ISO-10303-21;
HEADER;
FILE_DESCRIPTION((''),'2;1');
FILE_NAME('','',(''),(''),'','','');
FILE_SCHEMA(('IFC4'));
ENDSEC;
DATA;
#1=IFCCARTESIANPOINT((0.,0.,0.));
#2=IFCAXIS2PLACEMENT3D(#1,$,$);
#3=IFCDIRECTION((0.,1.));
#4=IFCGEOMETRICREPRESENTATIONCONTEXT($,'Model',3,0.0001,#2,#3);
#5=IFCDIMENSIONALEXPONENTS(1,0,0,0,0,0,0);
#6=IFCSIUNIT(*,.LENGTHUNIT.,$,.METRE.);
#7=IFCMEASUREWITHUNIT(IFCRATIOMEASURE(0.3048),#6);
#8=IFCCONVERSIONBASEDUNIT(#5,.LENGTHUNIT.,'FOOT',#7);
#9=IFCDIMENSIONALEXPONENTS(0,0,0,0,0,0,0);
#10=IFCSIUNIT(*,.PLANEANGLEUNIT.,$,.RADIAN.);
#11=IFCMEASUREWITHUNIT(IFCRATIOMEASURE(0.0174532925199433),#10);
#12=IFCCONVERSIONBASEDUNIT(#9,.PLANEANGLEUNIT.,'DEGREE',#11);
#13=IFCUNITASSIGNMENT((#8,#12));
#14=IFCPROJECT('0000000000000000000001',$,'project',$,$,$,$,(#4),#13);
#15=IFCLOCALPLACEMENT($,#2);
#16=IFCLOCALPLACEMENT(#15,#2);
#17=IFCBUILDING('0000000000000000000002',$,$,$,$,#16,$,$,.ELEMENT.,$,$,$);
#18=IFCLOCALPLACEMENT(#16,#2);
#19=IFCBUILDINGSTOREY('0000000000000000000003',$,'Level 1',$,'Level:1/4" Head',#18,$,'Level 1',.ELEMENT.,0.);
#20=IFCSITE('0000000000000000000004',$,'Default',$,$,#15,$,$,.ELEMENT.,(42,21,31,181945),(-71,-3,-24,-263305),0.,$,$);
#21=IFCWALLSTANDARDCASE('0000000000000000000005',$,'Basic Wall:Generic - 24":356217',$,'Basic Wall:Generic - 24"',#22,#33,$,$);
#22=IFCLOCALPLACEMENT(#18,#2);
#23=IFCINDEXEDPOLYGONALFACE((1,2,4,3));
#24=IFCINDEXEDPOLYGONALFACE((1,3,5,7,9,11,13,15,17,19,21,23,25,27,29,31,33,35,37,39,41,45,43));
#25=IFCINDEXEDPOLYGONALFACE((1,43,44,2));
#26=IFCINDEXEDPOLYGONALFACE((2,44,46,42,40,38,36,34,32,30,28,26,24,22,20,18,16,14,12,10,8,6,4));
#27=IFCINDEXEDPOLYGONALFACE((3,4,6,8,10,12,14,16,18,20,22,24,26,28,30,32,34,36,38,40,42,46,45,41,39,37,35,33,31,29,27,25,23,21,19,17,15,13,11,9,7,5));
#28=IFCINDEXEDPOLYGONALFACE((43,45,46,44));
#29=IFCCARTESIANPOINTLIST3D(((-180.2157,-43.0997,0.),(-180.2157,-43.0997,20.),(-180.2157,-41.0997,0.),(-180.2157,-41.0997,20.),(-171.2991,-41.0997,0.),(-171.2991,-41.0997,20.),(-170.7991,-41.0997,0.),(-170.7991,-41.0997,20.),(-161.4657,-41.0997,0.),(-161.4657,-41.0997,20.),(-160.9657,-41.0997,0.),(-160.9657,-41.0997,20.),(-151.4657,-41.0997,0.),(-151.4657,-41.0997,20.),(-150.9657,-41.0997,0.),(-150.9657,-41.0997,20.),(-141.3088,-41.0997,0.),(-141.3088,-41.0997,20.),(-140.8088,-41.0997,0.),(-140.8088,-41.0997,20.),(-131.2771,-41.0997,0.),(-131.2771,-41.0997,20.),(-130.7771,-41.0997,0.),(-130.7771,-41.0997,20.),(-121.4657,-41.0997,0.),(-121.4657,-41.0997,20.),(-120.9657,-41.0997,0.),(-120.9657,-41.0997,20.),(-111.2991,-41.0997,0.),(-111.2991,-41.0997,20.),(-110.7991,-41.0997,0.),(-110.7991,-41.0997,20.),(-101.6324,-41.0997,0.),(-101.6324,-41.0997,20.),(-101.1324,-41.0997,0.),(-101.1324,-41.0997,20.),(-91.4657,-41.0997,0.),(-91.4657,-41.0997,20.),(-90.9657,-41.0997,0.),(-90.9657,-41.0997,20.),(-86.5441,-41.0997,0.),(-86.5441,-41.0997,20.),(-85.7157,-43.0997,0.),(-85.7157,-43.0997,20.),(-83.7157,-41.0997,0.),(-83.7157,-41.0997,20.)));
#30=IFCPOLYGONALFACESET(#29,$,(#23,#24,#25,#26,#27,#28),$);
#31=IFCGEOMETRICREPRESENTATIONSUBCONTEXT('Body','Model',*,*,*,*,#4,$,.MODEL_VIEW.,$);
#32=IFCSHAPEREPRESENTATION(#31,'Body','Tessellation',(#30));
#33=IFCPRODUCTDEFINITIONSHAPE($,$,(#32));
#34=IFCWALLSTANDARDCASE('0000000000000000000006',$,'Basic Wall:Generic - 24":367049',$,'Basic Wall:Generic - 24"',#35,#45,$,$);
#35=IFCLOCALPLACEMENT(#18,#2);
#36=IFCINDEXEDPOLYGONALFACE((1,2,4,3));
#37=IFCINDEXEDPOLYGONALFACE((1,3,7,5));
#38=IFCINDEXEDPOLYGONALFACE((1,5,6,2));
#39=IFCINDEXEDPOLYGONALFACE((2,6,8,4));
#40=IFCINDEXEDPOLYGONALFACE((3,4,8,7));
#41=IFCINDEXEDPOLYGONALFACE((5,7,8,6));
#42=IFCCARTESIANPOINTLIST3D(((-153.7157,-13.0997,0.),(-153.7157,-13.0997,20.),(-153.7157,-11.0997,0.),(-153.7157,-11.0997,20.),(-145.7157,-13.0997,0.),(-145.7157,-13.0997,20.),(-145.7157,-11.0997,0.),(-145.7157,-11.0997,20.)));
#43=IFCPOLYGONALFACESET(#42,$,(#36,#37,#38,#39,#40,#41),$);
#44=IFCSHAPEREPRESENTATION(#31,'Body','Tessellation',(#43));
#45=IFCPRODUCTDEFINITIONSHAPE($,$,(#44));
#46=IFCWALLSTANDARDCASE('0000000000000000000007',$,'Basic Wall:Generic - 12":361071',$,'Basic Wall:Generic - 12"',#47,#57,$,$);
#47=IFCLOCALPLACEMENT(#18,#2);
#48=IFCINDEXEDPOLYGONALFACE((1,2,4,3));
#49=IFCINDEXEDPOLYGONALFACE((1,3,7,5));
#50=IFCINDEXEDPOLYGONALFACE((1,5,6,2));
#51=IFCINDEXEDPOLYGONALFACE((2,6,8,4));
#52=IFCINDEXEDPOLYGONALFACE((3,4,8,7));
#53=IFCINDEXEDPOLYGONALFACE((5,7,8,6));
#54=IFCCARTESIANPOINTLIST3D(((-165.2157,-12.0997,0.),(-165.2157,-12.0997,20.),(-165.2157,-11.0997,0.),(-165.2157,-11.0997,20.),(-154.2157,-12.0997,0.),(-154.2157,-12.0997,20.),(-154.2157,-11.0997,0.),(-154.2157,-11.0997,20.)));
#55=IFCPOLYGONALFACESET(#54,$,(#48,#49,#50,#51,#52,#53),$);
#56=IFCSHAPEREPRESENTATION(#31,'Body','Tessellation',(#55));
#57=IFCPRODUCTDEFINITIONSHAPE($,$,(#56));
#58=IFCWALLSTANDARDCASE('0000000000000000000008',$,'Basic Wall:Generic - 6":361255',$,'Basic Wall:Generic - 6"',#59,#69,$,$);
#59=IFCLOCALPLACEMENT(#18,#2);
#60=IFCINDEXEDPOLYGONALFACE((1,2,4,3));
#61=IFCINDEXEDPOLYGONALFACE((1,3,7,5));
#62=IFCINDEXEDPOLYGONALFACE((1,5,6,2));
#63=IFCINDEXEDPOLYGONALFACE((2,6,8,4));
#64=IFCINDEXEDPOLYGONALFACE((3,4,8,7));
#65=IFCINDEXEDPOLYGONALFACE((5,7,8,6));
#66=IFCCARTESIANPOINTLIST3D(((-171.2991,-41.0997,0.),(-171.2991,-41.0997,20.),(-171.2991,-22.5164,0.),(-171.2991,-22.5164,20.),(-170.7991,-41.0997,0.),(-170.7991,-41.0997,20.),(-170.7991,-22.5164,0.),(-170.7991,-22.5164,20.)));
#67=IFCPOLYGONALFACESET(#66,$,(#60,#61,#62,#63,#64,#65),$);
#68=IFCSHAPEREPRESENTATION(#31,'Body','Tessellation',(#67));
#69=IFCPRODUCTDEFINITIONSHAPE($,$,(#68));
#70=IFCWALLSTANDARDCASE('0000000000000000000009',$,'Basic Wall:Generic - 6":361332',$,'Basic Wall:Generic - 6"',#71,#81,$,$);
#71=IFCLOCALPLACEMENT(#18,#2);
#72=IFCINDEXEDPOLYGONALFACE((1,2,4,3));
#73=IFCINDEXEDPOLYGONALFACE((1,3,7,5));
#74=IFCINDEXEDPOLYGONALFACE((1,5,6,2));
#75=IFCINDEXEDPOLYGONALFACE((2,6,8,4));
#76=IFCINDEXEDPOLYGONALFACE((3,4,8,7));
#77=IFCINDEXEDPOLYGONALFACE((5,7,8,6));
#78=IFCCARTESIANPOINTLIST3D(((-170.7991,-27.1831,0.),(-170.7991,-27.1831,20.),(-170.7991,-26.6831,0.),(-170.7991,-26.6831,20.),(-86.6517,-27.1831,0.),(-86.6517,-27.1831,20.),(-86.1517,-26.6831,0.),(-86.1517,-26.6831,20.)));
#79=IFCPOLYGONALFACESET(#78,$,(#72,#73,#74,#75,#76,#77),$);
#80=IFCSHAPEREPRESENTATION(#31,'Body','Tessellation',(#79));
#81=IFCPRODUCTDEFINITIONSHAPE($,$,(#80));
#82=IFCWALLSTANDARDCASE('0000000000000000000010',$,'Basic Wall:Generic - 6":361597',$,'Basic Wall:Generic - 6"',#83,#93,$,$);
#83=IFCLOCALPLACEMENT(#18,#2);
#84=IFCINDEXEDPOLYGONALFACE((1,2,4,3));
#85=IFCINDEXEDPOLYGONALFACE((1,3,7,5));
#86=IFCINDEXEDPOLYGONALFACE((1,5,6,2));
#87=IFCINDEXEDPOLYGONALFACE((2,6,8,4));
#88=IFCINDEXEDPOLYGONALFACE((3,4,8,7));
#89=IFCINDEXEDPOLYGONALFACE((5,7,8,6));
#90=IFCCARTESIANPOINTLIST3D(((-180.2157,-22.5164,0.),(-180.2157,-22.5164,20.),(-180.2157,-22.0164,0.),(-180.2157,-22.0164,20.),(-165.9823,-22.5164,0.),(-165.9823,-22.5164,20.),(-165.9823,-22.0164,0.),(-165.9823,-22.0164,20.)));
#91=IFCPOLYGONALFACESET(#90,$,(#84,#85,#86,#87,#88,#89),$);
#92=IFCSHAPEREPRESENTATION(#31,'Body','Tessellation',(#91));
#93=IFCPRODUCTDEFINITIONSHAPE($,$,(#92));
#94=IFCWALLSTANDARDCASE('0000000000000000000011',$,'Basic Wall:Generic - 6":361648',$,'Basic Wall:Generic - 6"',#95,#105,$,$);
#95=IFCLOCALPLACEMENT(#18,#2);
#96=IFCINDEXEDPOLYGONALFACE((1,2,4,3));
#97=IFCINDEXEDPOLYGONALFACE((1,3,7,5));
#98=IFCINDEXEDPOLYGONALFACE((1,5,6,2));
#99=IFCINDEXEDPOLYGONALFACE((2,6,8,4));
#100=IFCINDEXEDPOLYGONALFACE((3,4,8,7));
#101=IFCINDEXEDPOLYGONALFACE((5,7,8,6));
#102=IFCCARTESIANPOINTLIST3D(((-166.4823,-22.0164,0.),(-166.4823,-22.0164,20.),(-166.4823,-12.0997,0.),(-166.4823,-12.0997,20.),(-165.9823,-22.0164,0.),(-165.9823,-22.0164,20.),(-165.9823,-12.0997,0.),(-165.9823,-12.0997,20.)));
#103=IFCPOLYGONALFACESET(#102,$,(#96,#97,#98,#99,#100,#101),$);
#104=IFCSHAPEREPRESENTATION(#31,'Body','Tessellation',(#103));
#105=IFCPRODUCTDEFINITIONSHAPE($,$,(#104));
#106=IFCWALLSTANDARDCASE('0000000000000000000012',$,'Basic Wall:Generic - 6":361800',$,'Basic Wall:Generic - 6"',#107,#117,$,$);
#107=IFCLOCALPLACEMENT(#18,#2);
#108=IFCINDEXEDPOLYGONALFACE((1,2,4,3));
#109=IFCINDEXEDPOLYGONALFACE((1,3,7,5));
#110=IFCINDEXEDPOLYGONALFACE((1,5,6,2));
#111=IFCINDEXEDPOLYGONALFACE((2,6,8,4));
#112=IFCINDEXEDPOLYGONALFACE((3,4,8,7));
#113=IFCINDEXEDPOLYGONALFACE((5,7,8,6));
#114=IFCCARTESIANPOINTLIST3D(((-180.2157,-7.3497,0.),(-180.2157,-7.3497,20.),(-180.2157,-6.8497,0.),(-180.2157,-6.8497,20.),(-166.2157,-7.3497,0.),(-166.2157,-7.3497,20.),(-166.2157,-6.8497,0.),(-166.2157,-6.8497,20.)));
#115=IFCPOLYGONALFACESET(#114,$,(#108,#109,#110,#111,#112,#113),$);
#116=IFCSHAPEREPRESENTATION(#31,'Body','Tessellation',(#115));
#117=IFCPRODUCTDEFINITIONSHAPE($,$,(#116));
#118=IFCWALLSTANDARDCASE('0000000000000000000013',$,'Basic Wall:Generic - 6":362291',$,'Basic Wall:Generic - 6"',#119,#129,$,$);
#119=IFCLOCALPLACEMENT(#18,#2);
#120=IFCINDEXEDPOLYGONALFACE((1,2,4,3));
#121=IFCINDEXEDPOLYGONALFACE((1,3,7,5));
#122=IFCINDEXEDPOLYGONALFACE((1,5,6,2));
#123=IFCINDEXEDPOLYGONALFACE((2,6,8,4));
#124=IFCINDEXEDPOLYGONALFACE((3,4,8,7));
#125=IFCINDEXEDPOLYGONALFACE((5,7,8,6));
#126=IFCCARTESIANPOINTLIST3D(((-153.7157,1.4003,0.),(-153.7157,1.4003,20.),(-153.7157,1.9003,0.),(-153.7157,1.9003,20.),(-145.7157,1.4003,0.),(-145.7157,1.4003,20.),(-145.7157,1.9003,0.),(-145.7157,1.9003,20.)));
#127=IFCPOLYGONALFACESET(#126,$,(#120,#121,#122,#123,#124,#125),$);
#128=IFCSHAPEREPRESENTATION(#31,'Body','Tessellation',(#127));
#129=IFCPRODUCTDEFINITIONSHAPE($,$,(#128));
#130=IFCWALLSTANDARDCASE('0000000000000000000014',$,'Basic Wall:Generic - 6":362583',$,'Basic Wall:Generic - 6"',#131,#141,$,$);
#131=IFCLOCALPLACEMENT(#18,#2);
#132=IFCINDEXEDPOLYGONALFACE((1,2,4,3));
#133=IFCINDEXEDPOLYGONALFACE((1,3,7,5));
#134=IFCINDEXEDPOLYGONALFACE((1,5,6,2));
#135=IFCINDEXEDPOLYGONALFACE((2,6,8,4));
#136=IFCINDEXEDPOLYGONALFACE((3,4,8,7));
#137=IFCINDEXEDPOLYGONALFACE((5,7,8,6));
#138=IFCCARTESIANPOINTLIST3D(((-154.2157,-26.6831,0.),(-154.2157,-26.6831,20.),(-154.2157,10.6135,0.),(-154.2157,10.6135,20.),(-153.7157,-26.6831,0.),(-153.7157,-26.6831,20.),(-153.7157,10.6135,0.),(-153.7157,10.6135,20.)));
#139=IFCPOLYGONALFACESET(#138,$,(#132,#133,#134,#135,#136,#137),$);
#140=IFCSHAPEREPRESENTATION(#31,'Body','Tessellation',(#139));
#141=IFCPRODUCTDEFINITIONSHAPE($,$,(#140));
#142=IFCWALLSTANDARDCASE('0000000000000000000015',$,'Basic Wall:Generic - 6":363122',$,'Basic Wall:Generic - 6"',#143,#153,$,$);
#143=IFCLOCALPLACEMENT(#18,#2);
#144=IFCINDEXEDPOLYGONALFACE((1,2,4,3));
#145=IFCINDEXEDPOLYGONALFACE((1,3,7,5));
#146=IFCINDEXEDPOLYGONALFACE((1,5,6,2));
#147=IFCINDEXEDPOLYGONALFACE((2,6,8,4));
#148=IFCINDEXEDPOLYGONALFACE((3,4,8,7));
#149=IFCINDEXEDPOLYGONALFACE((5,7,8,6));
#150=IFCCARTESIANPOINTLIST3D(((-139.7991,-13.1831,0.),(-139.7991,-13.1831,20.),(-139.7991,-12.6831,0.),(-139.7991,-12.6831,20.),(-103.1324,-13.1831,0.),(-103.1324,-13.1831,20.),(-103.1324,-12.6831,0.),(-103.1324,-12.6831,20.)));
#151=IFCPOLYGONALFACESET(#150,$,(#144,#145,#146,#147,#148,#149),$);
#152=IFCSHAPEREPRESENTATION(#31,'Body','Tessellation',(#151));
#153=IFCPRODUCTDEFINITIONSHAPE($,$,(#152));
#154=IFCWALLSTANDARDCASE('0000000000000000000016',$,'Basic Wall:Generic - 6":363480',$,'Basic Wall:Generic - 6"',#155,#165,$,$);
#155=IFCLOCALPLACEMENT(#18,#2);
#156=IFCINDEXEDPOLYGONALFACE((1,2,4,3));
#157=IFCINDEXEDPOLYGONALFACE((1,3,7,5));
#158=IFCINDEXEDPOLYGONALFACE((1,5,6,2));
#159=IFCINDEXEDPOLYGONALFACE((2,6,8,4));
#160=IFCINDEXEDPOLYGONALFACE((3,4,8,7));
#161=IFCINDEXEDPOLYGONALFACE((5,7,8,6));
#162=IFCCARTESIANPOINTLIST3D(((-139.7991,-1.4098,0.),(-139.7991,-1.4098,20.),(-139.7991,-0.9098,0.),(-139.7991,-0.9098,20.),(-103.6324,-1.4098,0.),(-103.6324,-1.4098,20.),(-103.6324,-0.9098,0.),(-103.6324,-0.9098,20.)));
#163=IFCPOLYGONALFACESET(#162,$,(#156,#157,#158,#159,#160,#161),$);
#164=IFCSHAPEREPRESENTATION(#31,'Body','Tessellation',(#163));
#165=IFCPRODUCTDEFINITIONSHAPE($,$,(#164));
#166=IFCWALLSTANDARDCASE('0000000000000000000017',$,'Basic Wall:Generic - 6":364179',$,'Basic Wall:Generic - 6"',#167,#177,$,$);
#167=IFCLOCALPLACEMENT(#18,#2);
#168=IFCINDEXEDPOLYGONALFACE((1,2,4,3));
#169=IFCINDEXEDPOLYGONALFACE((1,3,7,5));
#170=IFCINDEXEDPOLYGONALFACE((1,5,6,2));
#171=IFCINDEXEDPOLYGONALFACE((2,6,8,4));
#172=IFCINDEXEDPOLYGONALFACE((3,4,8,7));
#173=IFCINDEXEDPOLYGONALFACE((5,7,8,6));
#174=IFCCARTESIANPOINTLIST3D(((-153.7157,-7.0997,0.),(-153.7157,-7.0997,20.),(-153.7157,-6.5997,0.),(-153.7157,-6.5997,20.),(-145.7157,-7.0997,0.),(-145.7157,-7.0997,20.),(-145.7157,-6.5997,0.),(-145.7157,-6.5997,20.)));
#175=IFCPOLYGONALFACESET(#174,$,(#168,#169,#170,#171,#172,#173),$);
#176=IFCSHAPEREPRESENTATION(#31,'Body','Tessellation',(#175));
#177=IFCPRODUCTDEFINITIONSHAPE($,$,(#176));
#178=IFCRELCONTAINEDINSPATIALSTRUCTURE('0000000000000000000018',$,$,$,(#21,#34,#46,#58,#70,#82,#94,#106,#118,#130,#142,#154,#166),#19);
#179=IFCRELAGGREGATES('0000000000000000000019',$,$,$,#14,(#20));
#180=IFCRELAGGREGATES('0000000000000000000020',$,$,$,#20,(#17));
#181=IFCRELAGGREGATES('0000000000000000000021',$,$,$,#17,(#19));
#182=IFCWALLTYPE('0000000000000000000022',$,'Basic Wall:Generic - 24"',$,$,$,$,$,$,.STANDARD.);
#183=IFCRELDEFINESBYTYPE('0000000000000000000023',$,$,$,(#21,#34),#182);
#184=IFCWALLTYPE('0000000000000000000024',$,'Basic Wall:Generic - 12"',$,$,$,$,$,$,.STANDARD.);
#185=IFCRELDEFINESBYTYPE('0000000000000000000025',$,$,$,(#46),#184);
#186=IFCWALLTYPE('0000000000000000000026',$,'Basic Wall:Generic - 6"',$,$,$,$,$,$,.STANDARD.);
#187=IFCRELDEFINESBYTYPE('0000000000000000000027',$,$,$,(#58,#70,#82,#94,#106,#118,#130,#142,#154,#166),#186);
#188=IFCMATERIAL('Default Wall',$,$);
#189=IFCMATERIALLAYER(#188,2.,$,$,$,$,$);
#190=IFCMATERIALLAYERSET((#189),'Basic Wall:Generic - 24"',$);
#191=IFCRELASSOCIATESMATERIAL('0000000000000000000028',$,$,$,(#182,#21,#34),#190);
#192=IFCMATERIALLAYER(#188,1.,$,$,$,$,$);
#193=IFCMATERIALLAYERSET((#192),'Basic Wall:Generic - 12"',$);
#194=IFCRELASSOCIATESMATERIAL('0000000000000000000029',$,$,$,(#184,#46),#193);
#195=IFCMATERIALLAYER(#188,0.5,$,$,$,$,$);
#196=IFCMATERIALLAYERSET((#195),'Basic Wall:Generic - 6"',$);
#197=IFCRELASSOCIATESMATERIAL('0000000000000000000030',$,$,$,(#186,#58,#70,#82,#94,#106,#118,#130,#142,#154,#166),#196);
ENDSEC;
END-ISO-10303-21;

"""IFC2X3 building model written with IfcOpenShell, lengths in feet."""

from ifc_helpers import new_model, entity, si_unit, converted_unit, direction, frame, frame_2d, origin, place, context, subcontext, project, spatial, polyline, rectangle, outline, extrude, material, layer, layer_set, layer_usage, type_object, element, save


model = new_model("IFC2X3")

# Units and contexts
model_context = context("Model", 3, precision=0.0001, world=origin(), true_north=direction((0.0, 1.0)))
body_context = subcontext(model_context, "Body", "Model", "MODEL_VIEW")
ifc_project = project(units=[converted_unit("LENGTHUNIT", "FOOT", entity("IfcRatioMeasure", 0.3048), si_unit("LENGTHUNIT", "METRE"), dimensions=[1, 0, 0, 0, 0, 0, 0]), converted_unit("PLANEANGLEUNIT", "DEGREE", entity("IfcRatioMeasure", 0.0174532925199433), si_unit("PLANEANGLEUNIT", "RADIAN"), dimensions=[0, 0, 0, 0, 0, 0, 0])], contexts=[model_context])

# Site, building, storey
site_placement = place(None, origin())
site = spatial("IfcSite", under=ifc_project, at=site_placement, Name="Default", CompositionType="ELEMENT", RefLatitude=(42, 21, 31, 181945), RefLongitude=(-71, -3, -24, -263305), RefElevation=0.0)
building_placement = place(site_placement, origin())
building = spatial("IfcBuilding", under=site, at=building_placement, CompositionType="ELEMENT")
storey_placement = place(building_placement, origin())
storey = spatial("IfcBuildingStorey", under=building, at=storey_placement, Name="Level 1", ObjectType="Level:1/4\" Head", LongName="Level 1", CompositionType="ELEMENT", Elevation=0.0)

# Walls
ifc_material = material(Name="Default Wall")
ifc_layer_1 = layer(ifc_material, 2.0)
ifc_layer_set_1 = layer_set([ifc_layer_1], Name="Basic Wall:Generic - 24\"")
ifc_layer_usage_1 = layer_usage(ifc_layer_set_1, "AXIS2", "NEGATIVE", 1.0)
wall_type_1 = type_object("IfcWallType", Name="Basic Wall:Generic - 24\"", PredefinedType="STANDARD", material=ifc_layer_set_1)
wall_1_placement = place(storey_placement, frame((-180.2157, -42.0997, 0.0)))
element("IfcWallStandardCase", 1, at=wall_1_placement, inside=storey, type_object=wall_type_1, material=ifc_layer_usage_1, Name="Basic Wall:Generic - 24\":356217", ObjectType="Basic Wall:Generic - 24\"", context=body_context, shape_type="SweptSolid", body=[
    extrude(outline(polyline([(94.5, -1.0), (96.5, 1.0), (93.6716, 1.0), (89.25, 1.0), (88.75, 1.0), (79.0833, 1.0), (78.5833, 1.0), (69.4167, 1.0), (68.9167, 1.0), (59.25, 1.0), (58.75, 1.0), (49.4386, 1.0), (48.9386, 1.0), (39.4069, 1.0), (38.9069, 1.0), (29.25, 1.0), (28.75, 1.0), (19.25, 1.0), (18.75, 1.0), (9.4167, 1.0), (8.9167, 1.0), (0.0, 1.0), (0.0, -1.0), (94.5, -1.0)])), origin(), (0.0, 0.0, 1.0), 20.0),
])
ifc_layer_usage_2 = layer_usage(ifc_layer_set_1, "AXIS2", "NEGATIVE", 1.0)
wall_2_placement = place(storey_placement, frame((-153.7157, -12.0997, 0.0)))
element("IfcWallStandardCase", 2, at=wall_2_placement, inside=storey, type_object=wall_type_1, material=ifc_layer_usage_2, Name="Basic Wall:Generic - 24\":367049", ObjectType="Basic Wall:Generic - 24\"", context=body_context, shape_type="SweptSolid", body=[
    extrude(rectangle(XDim=8.0, YDim=2.0, at=frame_2d((4.0, 0.0), x_axis=(-1.0, 0.0))), origin(), (0.0, 0.0, 1.0), 20.0),
])
ifc_layer_2 = layer(ifc_material, 1.0)
ifc_layer_set_2 = layer_set([ifc_layer_2], Name="Basic Wall:Generic - 12\"")
ifc_layer_usage_3 = layer_usage(ifc_layer_set_2, "AXIS2", "NEGATIVE", 0.5)
wall_type_2 = type_object("IfcWallType", Name="Basic Wall:Generic - 12\"", PredefinedType="STANDARD", material=ifc_layer_set_2)
wall_3_placement = place(storey_placement, frame((-165.2157, -11.5997, 0.0)))
element("IfcWallStandardCase", 3, at=wall_3_placement, inside=storey, type_object=wall_type_2, material=ifc_layer_usage_3, Name="Basic Wall:Generic - 12\":361071", ObjectType="Basic Wall:Generic - 12\"", context=body_context, shape_type="SweptSolid", body=[
    extrude(rectangle(XDim=11.0, YDim=1.0, at=frame_2d((5.5, 0.0), x_axis=(-1.0, 0.0))), origin(), (0.0, 0.0, 1.0), 20.0),
])
ifc_layer_3 = layer(ifc_material, 0.5)
ifc_layer_set_3 = layer_set([ifc_layer_3], Name="Basic Wall:Generic - 6\"")
ifc_layer_usage_4 = layer_usage(ifc_layer_set_3, "AXIS2", "NEGATIVE", 0.25)
wall_type_3 = type_object("IfcWallType", Name="Basic Wall:Generic - 6\"", PredefinedType="STANDARD", material=ifc_layer_set_3)
wall_4_placement = place(storey_placement, frame((-171.0491, -41.0997, 0.0), z_axis=(0.0, 0.0, 1.0), x_axis=(0.0, 1.0, 0.0)))
element("IfcWallStandardCase", 4, at=wall_4_placement, inside=storey, type_object=wall_type_3, material=ifc_layer_usage_4, Name="Basic Wall:Generic - 6\":361255", ObjectType="Basic Wall:Generic - 6\"", context=body_context, shape_type="SweptSolid", body=[
    extrude(rectangle(XDim=18.5833, YDim=0.5, at=frame_2d((9.2917, 0.0), x_axis=(-1.0, 0.0))), origin(), (0.0, 0.0, 1.0), 20.0),
])
ifc_layer_usage_5 = layer_usage(ifc_layer_set_3, "AXIS2", "NEGATIVE", 0.25)
wall_5_placement = place(storey_placement, frame((-170.7991, -26.9331, 0.0)))
element("IfcWallStandardCase", 5, at=wall_5_placement, inside=storey, type_object=wall_type_3, material=ifc_layer_usage_5, Name="Basic Wall:Generic - 6\":361332", ObjectType="Basic Wall:Generic - 6\"", context=body_context, shape_type="SweptSolid", body=[
    extrude(outline(polyline([(84.1474, -0.25), (84.6474, 0.25), (0.0, 0.25), (0.0, -0.25), (84.1474, -0.25)])), origin(), (0.0, 0.0, 1.0), 20.0),
])
ifc_layer_usage_6 = layer_usage(ifc_layer_set_3, "AXIS2", "NEGATIVE", 0.25)
wall_6_placement = place(storey_placement, frame((-180.2157, -22.2664, 0.0)))
element("IfcWallStandardCase", 6, at=wall_6_placement, inside=storey, type_object=wall_type_3, material=ifc_layer_usage_6, Name="Basic Wall:Generic - 6\":361597", ObjectType="Basic Wall:Generic - 6\"", context=body_context, shape_type="SweptSolid", body=[
    extrude(rectangle(XDim=14.2334, YDim=0.5, at=frame_2d((7.1167, 0.0), x_axis=(-1.0, 0.0))), origin(), (0.0, 0.0, 1.0), 20.0),
])
ifc_layer_usage_7 = layer_usage(ifc_layer_set_3, "AXIS2", "NEGATIVE", 0.25)
wall_7_placement = place(storey_placement, frame((-166.2323, -22.0164, 0.0), z_axis=(0.0, 0.0, 1.0), x_axis=(0.0, 1.0, 0.0)))
element("IfcWallStandardCase", 7, at=wall_7_placement, inside=storey, type_object=wall_type_3, material=ifc_layer_usage_7, Name="Basic Wall:Generic - 6\":361648", ObjectType="Basic Wall:Generic - 6\"", context=body_context, shape_type="SweptSolid", body=[
    extrude(rectangle(XDim=9.9167, YDim=0.5, at=frame_2d((4.9583, 0.0), x_axis=(-1.0, 0.0))), origin(), (0.0, 0.0, 1.0), 20.0),
])
ifc_layer_usage_8 = layer_usage(ifc_layer_set_3, "AXIS2", "NEGATIVE", 0.25)
wall_8_placement = place(storey_placement, frame((-180.2157, -7.0997, 0.0)))
element("IfcWallStandardCase", 8, at=wall_8_placement, inside=storey, type_object=wall_type_3, material=ifc_layer_usage_8, Name="Basic Wall:Generic - 6\":361800", ObjectType="Basic Wall:Generic - 6\"", context=body_context, shape_type="SweptSolid", body=[
    extrude(rectangle(XDim=14.0, YDim=0.5, at=frame_2d((7.0, 0.0), x_axis=(-1.0, 0.0))), origin(), (0.0, 0.0, 1.0), 20.0),
])
ifc_layer_usage_9 = layer_usage(ifc_layer_set_3, "AXIS2", "NEGATIVE", 0.25)
wall_9_placement = place(storey_placement, frame((-145.7157, 1.6503, 0.0), z_axis=(0.0, 0.0, 1.0), x_axis=(-1.0, 0.0, 0.0)))
element("IfcWallStandardCase", 9, at=wall_9_placement, inside=storey, type_object=wall_type_3, material=ifc_layer_usage_9, Name="Basic Wall:Generic - 6\":362291", ObjectType="Basic Wall:Generic - 6\"", context=body_context, shape_type="SweptSolid", body=[
    extrude(rectangle(XDim=8.0, YDim=0.5, at=frame_2d((4.0, 0.0), x_axis=(-1.0, 0.0))), origin(), (0.0, 0.0, 1.0), 20.0),
])
ifc_layer_usage_10 = layer_usage(ifc_layer_set_3, "AXIS2", "NEGATIVE", 0.25)
wall_10_placement = place(storey_placement, frame((-153.9657, -26.6831, 0.0), z_axis=(0.0, 0.0, 1.0), x_axis=(0.0, 1.0, 0.0)))
element("IfcWallStandardCase", 10, at=wall_10_placement, inside=storey, type_object=wall_type_3, material=ifc_layer_usage_10, Name="Basic Wall:Generic - 6\":362583", ObjectType="Basic Wall:Generic - 6\"", context=body_context, shape_type="SweptSolid", body=[
    extrude(rectangle(XDim=37.2966, YDim=0.5, at=frame_2d((18.6483, 0.0), x_axis=(-1.0, 0.0))), origin(), (0.0, 0.0, 1.0), 20.0),
])
ifc_layer_usage_11 = layer_usage(ifc_layer_set_3, "AXIS2", "NEGATIVE", 0.25)
wall_11_placement = place(storey_placement, frame((-139.7991, -12.9331, 0.0)))
element("IfcWallStandardCase", 11, at=wall_11_placement, inside=storey, type_object=wall_type_3, material=ifc_layer_usage_11, Name="Basic Wall:Generic - 6\":363122", ObjectType="Basic Wall:Generic - 6\"", context=body_context, shape_type="SweptSolid", body=[
    extrude(rectangle(XDim=36.6667, YDim=0.5, at=frame_2d((18.3333, 0.0), x_axis=(-1.0, 0.0))), origin(), (0.0, 0.0, 1.0), 20.0),
])
ifc_layer_usage_12 = layer_usage(ifc_layer_set_3, "AXIS2", "NEGATIVE", 0.25)
wall_12_placement = place(storey_placement, frame((-139.7991, -1.1598, 0.0)))
element("IfcWallStandardCase", 12, at=wall_12_placement, inside=storey, type_object=wall_type_3, material=ifc_layer_usage_12, Name="Basic Wall:Generic - 6\":363480", ObjectType="Basic Wall:Generic - 6\"", context=body_context, shape_type="SweptSolid", body=[
    extrude(rectangle(XDim=36.1667, YDim=0.5, at=frame_2d((18.0833, 0.0), x_axis=(-1.0, 0.0))), origin(), (0.0, 0.0, 1.0), 20.0),
])
ifc_layer_usage_13 = layer_usage(ifc_layer_set_3, "AXIS2", "NEGATIVE", 0.25)
wall_13_placement = place(storey_placement, frame((-153.7157, -6.8497, 0.0)))
element("IfcWallStandardCase", 13, at=wall_13_placement, inside=storey, type_object=wall_type_3, material=ifc_layer_usage_13, Name="Basic Wall:Generic - 6\":364179", ObjectType="Basic Wall:Generic - 6\"", context=body_context, shape_type="SweptSolid", body=[
    extrude(rectangle(XDim=8.0, YDim=0.5, at=frame_2d((4.0, 0.0), x_axis=(-1.0, 0.0))), origin(), (0.0, 0.0, 1.0), 20.0),
])

save(model, "model.ifc")
